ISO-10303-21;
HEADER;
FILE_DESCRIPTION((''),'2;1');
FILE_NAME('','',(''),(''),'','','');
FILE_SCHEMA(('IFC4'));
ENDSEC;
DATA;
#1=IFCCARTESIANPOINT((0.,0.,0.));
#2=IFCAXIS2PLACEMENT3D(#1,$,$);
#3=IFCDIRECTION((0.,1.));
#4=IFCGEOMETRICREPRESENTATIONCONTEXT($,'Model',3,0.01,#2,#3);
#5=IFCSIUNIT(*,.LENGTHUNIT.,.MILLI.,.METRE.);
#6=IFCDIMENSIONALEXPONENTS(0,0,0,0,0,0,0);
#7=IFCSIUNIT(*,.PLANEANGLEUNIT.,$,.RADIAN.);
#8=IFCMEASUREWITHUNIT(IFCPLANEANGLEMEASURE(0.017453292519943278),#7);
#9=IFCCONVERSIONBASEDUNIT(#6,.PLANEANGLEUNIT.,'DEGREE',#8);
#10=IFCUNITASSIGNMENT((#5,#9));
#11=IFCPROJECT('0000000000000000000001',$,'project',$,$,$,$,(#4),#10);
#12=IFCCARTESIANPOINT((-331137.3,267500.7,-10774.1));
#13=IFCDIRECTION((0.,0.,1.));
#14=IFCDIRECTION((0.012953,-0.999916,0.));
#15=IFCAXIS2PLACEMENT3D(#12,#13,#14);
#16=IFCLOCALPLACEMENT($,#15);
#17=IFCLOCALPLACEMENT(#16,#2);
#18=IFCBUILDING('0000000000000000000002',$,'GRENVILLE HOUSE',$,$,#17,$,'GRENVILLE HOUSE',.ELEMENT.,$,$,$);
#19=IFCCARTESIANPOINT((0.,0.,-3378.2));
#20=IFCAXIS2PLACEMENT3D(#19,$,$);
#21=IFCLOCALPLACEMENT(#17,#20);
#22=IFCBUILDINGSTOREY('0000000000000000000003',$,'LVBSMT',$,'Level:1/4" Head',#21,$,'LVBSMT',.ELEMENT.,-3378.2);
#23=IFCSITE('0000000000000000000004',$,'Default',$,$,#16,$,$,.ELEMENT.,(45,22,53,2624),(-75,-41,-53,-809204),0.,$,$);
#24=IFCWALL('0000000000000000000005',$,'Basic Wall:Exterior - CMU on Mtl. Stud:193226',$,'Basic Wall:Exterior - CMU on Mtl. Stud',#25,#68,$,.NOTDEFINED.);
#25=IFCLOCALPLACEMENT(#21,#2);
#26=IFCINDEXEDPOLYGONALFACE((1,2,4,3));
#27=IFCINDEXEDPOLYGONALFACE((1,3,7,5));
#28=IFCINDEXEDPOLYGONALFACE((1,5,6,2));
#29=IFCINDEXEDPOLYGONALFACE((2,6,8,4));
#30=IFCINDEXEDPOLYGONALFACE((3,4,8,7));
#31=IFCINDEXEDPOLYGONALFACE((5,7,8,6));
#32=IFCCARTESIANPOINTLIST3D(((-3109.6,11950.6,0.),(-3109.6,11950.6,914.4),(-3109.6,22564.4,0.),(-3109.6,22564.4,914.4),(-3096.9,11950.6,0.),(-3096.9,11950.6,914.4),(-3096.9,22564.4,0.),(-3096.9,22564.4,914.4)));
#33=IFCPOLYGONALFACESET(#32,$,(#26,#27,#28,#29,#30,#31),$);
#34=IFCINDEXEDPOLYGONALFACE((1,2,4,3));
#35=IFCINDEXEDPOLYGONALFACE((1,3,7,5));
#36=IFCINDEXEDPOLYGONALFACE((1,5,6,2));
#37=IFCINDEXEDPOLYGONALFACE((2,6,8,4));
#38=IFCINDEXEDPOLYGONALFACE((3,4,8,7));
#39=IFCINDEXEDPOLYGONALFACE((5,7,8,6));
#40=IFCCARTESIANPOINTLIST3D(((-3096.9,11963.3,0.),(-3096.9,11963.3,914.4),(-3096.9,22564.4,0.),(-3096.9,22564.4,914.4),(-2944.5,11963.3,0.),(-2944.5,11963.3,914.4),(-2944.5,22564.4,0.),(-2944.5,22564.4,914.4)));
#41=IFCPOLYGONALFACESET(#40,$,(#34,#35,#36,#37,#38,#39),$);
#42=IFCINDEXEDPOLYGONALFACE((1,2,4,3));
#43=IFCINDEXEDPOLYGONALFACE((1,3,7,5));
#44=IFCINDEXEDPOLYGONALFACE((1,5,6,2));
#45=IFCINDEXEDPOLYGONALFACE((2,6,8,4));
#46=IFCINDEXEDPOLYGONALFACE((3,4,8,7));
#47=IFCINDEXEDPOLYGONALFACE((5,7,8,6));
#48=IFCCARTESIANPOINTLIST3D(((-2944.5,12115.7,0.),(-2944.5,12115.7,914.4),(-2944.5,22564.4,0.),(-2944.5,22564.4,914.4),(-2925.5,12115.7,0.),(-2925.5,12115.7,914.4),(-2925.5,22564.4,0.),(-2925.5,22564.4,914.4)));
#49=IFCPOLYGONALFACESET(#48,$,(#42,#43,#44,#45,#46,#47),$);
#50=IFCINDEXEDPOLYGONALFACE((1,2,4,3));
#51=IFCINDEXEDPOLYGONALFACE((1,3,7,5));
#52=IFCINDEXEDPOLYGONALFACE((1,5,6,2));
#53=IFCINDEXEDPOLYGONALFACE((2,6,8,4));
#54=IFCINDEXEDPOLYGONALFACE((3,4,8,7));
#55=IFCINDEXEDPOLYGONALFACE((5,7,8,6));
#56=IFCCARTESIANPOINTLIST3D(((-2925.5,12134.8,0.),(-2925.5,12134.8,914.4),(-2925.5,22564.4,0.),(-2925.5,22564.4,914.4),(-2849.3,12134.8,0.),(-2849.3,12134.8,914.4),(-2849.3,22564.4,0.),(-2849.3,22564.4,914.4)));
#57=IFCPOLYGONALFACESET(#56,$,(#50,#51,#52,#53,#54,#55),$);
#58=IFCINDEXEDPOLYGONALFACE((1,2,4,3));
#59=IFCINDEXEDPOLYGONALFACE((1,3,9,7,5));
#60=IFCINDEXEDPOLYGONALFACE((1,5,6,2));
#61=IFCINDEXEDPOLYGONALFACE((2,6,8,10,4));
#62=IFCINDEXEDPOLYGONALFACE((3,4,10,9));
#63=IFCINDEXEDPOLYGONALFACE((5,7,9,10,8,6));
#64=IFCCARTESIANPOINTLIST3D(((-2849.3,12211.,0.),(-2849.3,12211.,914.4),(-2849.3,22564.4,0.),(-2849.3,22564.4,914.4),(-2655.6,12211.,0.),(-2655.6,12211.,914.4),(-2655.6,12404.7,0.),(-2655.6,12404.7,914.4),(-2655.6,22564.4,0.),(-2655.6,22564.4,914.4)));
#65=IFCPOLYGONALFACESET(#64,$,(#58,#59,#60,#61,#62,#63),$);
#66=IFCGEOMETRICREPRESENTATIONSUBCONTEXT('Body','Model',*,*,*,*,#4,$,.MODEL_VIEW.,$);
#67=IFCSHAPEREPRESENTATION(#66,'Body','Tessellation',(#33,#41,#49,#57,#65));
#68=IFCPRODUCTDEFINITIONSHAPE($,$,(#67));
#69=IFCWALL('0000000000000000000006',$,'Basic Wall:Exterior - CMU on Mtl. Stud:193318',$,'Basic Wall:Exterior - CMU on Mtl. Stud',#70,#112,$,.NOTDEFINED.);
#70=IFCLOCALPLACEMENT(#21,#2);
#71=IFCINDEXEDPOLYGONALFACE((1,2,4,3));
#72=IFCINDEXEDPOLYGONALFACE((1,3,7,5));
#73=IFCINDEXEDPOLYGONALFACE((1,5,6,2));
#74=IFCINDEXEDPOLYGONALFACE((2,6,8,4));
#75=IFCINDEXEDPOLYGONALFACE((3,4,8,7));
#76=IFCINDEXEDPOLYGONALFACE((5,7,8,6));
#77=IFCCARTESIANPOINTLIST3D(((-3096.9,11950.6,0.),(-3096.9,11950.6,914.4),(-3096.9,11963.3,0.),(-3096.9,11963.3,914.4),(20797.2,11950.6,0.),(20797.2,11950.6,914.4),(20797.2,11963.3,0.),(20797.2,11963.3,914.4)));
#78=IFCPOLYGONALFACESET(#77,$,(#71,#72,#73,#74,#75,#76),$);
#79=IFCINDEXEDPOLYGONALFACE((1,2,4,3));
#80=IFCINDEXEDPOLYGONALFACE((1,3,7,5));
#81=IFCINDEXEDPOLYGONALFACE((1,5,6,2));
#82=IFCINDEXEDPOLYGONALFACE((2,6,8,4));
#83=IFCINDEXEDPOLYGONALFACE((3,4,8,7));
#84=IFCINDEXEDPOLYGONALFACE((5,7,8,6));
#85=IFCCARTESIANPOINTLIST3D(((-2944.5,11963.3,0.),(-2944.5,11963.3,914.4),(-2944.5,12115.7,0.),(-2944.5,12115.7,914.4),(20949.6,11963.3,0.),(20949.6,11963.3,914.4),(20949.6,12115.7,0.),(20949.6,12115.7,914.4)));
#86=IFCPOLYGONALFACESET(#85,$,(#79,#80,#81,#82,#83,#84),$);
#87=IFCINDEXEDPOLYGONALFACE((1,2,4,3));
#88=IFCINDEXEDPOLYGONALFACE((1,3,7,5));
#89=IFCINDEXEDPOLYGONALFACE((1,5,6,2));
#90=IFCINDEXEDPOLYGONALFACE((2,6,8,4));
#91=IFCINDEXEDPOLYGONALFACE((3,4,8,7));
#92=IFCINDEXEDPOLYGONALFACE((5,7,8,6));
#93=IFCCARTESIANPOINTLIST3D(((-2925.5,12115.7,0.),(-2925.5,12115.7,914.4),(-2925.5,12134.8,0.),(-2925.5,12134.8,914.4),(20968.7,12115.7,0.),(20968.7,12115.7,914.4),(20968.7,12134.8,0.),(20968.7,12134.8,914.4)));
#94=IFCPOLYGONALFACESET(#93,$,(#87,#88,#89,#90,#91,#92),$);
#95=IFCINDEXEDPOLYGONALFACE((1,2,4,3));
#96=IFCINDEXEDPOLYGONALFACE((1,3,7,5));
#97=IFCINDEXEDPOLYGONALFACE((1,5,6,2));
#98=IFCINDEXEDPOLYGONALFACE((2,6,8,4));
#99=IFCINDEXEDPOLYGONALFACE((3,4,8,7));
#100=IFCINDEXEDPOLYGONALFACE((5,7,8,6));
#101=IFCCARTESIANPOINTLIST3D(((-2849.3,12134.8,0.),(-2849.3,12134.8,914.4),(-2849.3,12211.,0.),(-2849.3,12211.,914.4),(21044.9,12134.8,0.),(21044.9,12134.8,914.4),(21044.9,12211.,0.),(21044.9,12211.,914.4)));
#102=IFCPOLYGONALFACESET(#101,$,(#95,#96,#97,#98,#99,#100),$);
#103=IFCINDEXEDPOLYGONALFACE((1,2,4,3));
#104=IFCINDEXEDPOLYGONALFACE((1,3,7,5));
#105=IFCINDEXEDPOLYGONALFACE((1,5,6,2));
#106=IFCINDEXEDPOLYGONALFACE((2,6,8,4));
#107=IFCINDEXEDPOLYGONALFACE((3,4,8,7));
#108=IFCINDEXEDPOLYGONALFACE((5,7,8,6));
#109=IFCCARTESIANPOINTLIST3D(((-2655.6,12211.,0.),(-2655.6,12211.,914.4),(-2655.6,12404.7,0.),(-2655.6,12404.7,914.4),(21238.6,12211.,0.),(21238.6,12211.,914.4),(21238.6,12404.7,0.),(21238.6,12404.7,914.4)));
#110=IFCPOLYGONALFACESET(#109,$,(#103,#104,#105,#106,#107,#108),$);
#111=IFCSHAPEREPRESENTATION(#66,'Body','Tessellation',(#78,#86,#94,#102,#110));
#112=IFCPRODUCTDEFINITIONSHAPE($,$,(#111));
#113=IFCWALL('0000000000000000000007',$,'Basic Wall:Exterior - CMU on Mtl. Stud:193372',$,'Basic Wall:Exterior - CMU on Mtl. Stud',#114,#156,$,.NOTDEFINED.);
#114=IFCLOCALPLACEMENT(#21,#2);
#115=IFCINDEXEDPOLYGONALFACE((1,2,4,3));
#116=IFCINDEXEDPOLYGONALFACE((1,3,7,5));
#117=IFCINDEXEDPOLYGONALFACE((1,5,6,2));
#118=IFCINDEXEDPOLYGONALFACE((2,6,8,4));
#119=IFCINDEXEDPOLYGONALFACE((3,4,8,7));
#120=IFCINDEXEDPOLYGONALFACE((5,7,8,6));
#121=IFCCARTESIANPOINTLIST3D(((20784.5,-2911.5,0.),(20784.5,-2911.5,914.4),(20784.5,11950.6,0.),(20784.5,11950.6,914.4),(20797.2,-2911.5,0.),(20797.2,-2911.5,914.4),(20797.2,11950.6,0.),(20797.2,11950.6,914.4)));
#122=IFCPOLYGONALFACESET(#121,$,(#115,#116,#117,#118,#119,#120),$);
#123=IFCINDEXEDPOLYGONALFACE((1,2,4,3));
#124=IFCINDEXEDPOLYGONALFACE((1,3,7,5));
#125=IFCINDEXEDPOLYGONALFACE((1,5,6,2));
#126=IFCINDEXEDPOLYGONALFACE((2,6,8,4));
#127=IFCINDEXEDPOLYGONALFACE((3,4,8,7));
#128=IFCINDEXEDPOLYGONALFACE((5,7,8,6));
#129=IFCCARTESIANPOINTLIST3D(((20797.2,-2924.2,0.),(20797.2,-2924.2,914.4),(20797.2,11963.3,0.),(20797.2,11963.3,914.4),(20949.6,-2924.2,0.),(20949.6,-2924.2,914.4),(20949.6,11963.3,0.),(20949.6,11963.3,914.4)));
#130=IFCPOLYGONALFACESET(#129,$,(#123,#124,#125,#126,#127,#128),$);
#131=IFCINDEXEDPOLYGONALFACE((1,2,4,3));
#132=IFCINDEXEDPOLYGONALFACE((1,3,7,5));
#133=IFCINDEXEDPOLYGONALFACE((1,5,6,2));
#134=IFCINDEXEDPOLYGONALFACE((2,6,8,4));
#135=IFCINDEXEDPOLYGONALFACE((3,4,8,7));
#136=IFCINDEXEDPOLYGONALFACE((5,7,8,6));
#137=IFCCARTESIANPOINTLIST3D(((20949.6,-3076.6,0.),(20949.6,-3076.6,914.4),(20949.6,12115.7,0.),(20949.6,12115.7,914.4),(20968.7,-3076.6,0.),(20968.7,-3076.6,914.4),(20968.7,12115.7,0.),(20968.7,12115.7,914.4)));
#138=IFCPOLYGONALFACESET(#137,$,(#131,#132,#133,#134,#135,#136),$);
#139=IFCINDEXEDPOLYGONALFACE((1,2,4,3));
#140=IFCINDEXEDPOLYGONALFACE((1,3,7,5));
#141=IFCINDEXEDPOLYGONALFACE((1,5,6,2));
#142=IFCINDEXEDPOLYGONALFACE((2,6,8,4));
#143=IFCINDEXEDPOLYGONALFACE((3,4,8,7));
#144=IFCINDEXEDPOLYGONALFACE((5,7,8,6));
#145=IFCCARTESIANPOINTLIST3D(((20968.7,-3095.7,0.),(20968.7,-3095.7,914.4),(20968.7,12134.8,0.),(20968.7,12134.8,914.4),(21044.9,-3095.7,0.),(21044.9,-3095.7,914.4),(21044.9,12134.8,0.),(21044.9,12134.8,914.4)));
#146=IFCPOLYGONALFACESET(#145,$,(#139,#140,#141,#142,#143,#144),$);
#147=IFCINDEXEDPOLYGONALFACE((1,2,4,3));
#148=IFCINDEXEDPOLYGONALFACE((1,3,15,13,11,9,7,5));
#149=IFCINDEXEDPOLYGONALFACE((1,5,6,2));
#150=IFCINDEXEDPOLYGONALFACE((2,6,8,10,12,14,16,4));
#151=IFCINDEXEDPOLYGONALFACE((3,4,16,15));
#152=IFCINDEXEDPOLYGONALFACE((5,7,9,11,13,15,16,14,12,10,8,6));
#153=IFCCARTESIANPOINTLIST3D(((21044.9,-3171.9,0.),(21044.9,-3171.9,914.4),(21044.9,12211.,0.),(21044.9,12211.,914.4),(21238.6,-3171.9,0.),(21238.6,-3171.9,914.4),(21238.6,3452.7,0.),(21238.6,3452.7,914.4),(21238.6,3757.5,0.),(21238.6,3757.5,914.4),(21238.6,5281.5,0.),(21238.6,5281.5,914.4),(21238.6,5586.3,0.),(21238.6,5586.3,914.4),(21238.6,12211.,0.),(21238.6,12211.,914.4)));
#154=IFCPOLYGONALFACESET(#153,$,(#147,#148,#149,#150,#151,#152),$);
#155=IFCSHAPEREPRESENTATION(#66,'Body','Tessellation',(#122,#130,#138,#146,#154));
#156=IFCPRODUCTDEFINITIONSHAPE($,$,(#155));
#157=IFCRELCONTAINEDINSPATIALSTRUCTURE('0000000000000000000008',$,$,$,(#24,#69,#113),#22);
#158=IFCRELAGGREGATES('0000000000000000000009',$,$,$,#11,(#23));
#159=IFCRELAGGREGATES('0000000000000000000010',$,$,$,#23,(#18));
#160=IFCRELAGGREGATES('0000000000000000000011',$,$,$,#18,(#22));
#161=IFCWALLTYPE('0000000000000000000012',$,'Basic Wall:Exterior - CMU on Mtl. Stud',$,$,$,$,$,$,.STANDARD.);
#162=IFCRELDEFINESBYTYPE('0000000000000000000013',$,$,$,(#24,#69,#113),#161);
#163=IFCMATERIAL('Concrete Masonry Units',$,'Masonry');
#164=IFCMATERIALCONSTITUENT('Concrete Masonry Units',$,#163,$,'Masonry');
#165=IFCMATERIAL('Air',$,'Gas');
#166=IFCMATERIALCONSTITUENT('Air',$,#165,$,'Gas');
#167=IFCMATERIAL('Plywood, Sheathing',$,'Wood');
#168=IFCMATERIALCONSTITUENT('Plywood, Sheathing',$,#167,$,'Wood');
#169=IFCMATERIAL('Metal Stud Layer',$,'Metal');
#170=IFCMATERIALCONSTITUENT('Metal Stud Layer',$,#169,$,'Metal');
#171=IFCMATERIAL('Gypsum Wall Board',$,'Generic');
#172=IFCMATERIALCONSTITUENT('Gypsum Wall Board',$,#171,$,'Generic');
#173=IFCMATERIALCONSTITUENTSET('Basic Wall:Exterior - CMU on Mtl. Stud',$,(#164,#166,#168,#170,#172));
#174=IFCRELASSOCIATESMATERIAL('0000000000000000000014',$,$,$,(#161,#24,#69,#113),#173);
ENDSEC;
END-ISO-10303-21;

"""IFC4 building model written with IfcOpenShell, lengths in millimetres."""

from ifc_helpers import new_model, entity, si_unit, converted_unit, direction, frame, origin, place, context, subcontext, project, spatial, indexed_curve, outline, extrude, material, constituent, constituent_set, type_object, element, save


model = new_model("IFC4")

# Units and contexts
model_context = context("Model", 3, precision=0.01, world=origin(), true_north=direction((0.0, 1.0)))
body_context = subcontext(model_context, "Body", "Model", "MODEL_VIEW")
ifc_project = project(units=[si_unit("LENGTHUNIT", "METRE", prefix="MILLI"), converted_unit("PLANEANGLEUNIT", "DEGREE", entity("IfcPlaneAngleMeasure", 0.017453292519943278), si_unit("PLANEANGLEUNIT", "RADIAN"), dimensions=[0, 0, 0, 0, 0, 0, 0])], contexts=[model_context])

# Site, building, storey
site_placement = place(None, frame((-331137.3, 267500.7, -10774.1), z_axis=(0.0, 0.0, 1.0), x_axis=(0.012953, -0.999916, 0.0)))
site = spatial("IfcSite", under=ifc_project, at=site_placement, Name="Default", CompositionType="ELEMENT", RefLatitude=(45, 22, 53, 2624), RefLongitude=(-75, -41, -53, -809204), RefElevation=0.0)
building_placement = place(site_placement, origin())
building = spatial("IfcBuilding", under=site, at=building_placement, Name="GRENVILLE HOUSE", LongName="GRENVILLE HOUSE", CompositionType="ELEMENT")
storey_placement = place(building_placement, frame((0.0, 0.0, -3378.2)))
storey = spatial("IfcBuildingStorey", under=building, at=storey_placement, Name="LVBSMT", ObjectType="Level:1/4\" Head", LongName="LVBSMT", CompositionType="ELEMENT", Elevation=-3378.2)

# Shared definitions
ifc_material_1 = material(Name="Concrete Masonry Units", Category="Masonry")

# Walls
ifc_constituent_1 = constituent(ifc_material_1, Name="Concrete Masonry Units", Category="Masonry")
ifc_material_2 = material(Name="Air", Category="Gas")
ifc_constituent_2 = constituent(ifc_material_2, Name="Air", Category="Gas")
ifc_material_3 = material(Name="Plywood, Sheathing", Category="Wood")
ifc_constituent_3 = constituent(ifc_material_3, Name="Plywood, Sheathing", Category="Wood")
ifc_material_4 = material(Name="Metal Stud Layer", Category="Metal")
ifc_constituent_4 = constituent(ifc_material_4, Name="Metal Stud Layer", Category="Metal")
ifc_material_5 = material(Name="Gypsum Wall Board", Category="Generic")
ifc_constituent_5 = constituent(ifc_material_5, Name="Gypsum Wall Board", Category="Generic")
ifc_constituent_set = constituent_set(constituents=[ifc_constituent_1, ifc_constituent_2, ifc_constituent_3, ifc_constituent_4, ifc_constituent_5], Name="Basic Wall:Exterior - CMU on Mtl. Stud")
wall_type_1 = type_object("IfcWallType", Name="Basic Wall:Exterior - CMU on Mtl. Stud", PredefinedType="STANDARD", material=ifc_constituent_set)
wall_1_placement = place(storey_placement, frame((-2882.6, 22564.4, 0.0), z_axis=(0.0, 0.0, 1.0), x_axis=(0.0, -1.0, 0.0)))
element("IfcWall", 1, at=wall_1_placement, inside=storey, type_object=wall_type_1, material=ifc_constituent_set, Name="Basic Wall:Exterior - CMU on Mtl. Stud:193226", ObjectType="Basic Wall:Exterior - CMU on Mtl. Stud", PredefinedType="NOTDEFINED", context=body_context, shape_type="SweptSolid", body=[
    extrude(outline(indexed_curve([(-6.4, -5306.9), (6.3, -5306.9), (6.4, 5306.9), (-6.3, 5306.9), (-6.4, -5306.9)], self_intersect=False)), frame((5306.9, -220.7, 0.0), z_axis=(0.0, 0.0, 1.0), x_axis=(0.0, 1.0, 0.0)), (0.0, 0.0, 1.0), 914.4),
    extrude(outline(indexed_curve([(-5300.5, -76.2), (5300.5, -76.2), (5300.5, 76.2), (-5300.5, 76.2), (-5300.5, -76.2)], self_intersect=False)), frame((5300.5, -138.1, 0.0)), (0.0, 0.0, 1.0), 914.4),
    extrude(outline(indexed_curve([(-5224.3, -9.5), (5224.3, -9.5), (5224.3, 9.5), (-5224.3, 9.5), (-5224.3, -9.5)], self_intersect=False)), frame((5224.3, -52.4, 0.0)), (0.0, 0.0, 1.0), 914.4),
    extrude(outline(indexed_curve([(-5214.8, -38.1), (5214.8, -38.1), (5214.8, 38.1), (-5214.8, 38.1), (-5214.8, -38.1)], self_intersect=False)), frame((5214.8, -4.8, 0.0)), (0.0, 0.0, 1.0), 914.4),
    extrude(outline(indexed_curve([(-3986.4, -77.5), (6173.3, -77.5), (6173.3, 116.2), (-4180.1, 116.2), (-4180.1, -77.5), (-3986.4, -77.5)], self_intersect=False)), frame((6173.3, 149.5, 0.0), z_axis=(0.0, 0.0, 1.0), x_axis=(-1.0, 0.0, 0.0)), (0.0, 0.0, 1.0), 914.4),
])
wall_2_placement = place(storey_placement, frame((-2655.6, 12177.6, 0.0)))
element("IfcWall", 2, at=wall_2_placement, inside=storey, type_object=wall_type_1, material=ifc_constituent_set, Name="Basic Wall:Exterior - CMU on Mtl. Stud:193318", ObjectType="Basic Wall:Exterior - CMU on Mtl. Stud", PredefinedType="NOTDEFINED", context=body_context, shape_type="SweptSolid", body=[
    extrude(outline(indexed_curve([(-6.4, -11947.1), (6.3, -11947.1), (6.4, 11947.1), (-6.3, 11947.1), (-6.4, -11947.1)], self_intersect=False)), frame((11505.7, -220.7, 0.0), z_axis=(0.0, 0.0, 1.0), x_axis=(0.0, 1.0, 0.0)), (0.0, 0.0, 1.0), 914.4),
    extrude(outline(indexed_curve([(-11947.1, -76.2), (11947.1, -76.2), (11947.1, 76.2), (-11947.1, 76.2), (-11947.1, -76.2)], self_intersect=False)), frame((11658.1, -138.1, 0.0)), (0.0, 0.0, 1.0), 914.4),
    extrude(outline(indexed_curve([(-11947.1, -9.5), (11947.1, -9.5), (11947.1, 9.5), (-11947.1, 9.5), (-11947.1, -9.5)], self_intersect=False)), frame((11677.2, -52.4, 0.0)), (0.0, 0.0, 1.0), 914.4),
    extrude(outline(indexed_curve([(-11947.1, -38.1), (11947.1, -38.1), (11947.1, 38.1), (-11947.1, 38.1), (-11947.1, -38.1)], self_intersect=False)), frame((11753.4, -4.8, 0.0)), (0.0, 0.0, 1.0), 914.4),
    extrude(outline(indexed_curve([(-96.8, -11947.1), (96.8, -11947.1), (96.8, 11947.1), (-96.8, 11947.1), (-96.8, -11947.1)], self_intersect=False)), frame((11947.1, 130.2, 0.0), z_axis=(0.0, 0.0, 1.0), x_axis=(0.0, -1.0, 0.0)), (0.0, 0.0, 1.0), 914.4),
])
wall_3_placement = place(storey_placement, frame((21011.5, 11950.6, 0.0), z_axis=(0.0, 0.0, 1.0), x_axis=(0.0, -1.0, 0.0)))
element("IfcWall", 3, at=wall_3_placement, inside=storey, type_object=wall_type_1, material=ifc_constituent_set, Name="Basic Wall:Exterior - CMU on Mtl. Stud:193372", ObjectType="Basic Wall:Exterior - CMU on Mtl. Stud", PredefinedType="NOTDEFINED", context=body_context, shape_type="SweptSolid", body=[
    extrude(outline(indexed_curve([(-6.4, -7431.1), (6.3, -7431.1), (6.4, 7431.1), (-6.3, 7431.1), (-6.4, -7431.1)], self_intersect=False)), frame((7431.1, -220.7, 0.0), z_axis=(0.0, 0.0, 1.0), x_axis=(0.0, 1.0, 0.0)), (0.0, 0.0, 1.0), 914.4),
    extrude(outline(indexed_curve([(-7443.8, -76.2), (7443.8, -76.2), (7443.8, 76.2), (-7443.8, 76.2), (-7443.8, -76.2)], self_intersect=False)), frame((7431.1, -138.1, 0.0)), (0.0, 0.0, 1.0), 914.4),
    extrude(outline(indexed_curve([(-7596.2, -9.5), (7596.2, -9.5), (7596.2, 9.5), (-7596.2, 9.5), (-7596.2, -9.5)], self_intersect=False)), frame((7431.1, -52.4, 0.0)), (0.0, 0.0, 1.0), 914.4),
    extrude(outline(indexed_curve([(-7615.2, -38.1), (7615.2, -38.1), (7615.2, 38.1), (-7615.2, 38.1), (-7615.2, -38.1)], self_intersect=False)), frame((7431.1, -4.8, 0.0)), (0.0, 0.0, 1.0), 914.4),
    extrude(outline(indexed_curve([(-1066.8, -48.4), (-762.0, -48.4), (762.0, -48.4), (1066.8, -48.4), (7691.4, -48.4), (7691.4, 145.3), (-7691.4, 145.3), (-7691.4, -48.4), (-1066.8, -48.4)], self_intersect=False)), frame((7431.1, 178.6, 0.0), z_axis=(0.0, 0.0, 1.0), x_axis=(-1.0, 0.0, 0.0)), (0.0, 0.0, 1.0), 914.4),
])

save(model, "model.ifc")
